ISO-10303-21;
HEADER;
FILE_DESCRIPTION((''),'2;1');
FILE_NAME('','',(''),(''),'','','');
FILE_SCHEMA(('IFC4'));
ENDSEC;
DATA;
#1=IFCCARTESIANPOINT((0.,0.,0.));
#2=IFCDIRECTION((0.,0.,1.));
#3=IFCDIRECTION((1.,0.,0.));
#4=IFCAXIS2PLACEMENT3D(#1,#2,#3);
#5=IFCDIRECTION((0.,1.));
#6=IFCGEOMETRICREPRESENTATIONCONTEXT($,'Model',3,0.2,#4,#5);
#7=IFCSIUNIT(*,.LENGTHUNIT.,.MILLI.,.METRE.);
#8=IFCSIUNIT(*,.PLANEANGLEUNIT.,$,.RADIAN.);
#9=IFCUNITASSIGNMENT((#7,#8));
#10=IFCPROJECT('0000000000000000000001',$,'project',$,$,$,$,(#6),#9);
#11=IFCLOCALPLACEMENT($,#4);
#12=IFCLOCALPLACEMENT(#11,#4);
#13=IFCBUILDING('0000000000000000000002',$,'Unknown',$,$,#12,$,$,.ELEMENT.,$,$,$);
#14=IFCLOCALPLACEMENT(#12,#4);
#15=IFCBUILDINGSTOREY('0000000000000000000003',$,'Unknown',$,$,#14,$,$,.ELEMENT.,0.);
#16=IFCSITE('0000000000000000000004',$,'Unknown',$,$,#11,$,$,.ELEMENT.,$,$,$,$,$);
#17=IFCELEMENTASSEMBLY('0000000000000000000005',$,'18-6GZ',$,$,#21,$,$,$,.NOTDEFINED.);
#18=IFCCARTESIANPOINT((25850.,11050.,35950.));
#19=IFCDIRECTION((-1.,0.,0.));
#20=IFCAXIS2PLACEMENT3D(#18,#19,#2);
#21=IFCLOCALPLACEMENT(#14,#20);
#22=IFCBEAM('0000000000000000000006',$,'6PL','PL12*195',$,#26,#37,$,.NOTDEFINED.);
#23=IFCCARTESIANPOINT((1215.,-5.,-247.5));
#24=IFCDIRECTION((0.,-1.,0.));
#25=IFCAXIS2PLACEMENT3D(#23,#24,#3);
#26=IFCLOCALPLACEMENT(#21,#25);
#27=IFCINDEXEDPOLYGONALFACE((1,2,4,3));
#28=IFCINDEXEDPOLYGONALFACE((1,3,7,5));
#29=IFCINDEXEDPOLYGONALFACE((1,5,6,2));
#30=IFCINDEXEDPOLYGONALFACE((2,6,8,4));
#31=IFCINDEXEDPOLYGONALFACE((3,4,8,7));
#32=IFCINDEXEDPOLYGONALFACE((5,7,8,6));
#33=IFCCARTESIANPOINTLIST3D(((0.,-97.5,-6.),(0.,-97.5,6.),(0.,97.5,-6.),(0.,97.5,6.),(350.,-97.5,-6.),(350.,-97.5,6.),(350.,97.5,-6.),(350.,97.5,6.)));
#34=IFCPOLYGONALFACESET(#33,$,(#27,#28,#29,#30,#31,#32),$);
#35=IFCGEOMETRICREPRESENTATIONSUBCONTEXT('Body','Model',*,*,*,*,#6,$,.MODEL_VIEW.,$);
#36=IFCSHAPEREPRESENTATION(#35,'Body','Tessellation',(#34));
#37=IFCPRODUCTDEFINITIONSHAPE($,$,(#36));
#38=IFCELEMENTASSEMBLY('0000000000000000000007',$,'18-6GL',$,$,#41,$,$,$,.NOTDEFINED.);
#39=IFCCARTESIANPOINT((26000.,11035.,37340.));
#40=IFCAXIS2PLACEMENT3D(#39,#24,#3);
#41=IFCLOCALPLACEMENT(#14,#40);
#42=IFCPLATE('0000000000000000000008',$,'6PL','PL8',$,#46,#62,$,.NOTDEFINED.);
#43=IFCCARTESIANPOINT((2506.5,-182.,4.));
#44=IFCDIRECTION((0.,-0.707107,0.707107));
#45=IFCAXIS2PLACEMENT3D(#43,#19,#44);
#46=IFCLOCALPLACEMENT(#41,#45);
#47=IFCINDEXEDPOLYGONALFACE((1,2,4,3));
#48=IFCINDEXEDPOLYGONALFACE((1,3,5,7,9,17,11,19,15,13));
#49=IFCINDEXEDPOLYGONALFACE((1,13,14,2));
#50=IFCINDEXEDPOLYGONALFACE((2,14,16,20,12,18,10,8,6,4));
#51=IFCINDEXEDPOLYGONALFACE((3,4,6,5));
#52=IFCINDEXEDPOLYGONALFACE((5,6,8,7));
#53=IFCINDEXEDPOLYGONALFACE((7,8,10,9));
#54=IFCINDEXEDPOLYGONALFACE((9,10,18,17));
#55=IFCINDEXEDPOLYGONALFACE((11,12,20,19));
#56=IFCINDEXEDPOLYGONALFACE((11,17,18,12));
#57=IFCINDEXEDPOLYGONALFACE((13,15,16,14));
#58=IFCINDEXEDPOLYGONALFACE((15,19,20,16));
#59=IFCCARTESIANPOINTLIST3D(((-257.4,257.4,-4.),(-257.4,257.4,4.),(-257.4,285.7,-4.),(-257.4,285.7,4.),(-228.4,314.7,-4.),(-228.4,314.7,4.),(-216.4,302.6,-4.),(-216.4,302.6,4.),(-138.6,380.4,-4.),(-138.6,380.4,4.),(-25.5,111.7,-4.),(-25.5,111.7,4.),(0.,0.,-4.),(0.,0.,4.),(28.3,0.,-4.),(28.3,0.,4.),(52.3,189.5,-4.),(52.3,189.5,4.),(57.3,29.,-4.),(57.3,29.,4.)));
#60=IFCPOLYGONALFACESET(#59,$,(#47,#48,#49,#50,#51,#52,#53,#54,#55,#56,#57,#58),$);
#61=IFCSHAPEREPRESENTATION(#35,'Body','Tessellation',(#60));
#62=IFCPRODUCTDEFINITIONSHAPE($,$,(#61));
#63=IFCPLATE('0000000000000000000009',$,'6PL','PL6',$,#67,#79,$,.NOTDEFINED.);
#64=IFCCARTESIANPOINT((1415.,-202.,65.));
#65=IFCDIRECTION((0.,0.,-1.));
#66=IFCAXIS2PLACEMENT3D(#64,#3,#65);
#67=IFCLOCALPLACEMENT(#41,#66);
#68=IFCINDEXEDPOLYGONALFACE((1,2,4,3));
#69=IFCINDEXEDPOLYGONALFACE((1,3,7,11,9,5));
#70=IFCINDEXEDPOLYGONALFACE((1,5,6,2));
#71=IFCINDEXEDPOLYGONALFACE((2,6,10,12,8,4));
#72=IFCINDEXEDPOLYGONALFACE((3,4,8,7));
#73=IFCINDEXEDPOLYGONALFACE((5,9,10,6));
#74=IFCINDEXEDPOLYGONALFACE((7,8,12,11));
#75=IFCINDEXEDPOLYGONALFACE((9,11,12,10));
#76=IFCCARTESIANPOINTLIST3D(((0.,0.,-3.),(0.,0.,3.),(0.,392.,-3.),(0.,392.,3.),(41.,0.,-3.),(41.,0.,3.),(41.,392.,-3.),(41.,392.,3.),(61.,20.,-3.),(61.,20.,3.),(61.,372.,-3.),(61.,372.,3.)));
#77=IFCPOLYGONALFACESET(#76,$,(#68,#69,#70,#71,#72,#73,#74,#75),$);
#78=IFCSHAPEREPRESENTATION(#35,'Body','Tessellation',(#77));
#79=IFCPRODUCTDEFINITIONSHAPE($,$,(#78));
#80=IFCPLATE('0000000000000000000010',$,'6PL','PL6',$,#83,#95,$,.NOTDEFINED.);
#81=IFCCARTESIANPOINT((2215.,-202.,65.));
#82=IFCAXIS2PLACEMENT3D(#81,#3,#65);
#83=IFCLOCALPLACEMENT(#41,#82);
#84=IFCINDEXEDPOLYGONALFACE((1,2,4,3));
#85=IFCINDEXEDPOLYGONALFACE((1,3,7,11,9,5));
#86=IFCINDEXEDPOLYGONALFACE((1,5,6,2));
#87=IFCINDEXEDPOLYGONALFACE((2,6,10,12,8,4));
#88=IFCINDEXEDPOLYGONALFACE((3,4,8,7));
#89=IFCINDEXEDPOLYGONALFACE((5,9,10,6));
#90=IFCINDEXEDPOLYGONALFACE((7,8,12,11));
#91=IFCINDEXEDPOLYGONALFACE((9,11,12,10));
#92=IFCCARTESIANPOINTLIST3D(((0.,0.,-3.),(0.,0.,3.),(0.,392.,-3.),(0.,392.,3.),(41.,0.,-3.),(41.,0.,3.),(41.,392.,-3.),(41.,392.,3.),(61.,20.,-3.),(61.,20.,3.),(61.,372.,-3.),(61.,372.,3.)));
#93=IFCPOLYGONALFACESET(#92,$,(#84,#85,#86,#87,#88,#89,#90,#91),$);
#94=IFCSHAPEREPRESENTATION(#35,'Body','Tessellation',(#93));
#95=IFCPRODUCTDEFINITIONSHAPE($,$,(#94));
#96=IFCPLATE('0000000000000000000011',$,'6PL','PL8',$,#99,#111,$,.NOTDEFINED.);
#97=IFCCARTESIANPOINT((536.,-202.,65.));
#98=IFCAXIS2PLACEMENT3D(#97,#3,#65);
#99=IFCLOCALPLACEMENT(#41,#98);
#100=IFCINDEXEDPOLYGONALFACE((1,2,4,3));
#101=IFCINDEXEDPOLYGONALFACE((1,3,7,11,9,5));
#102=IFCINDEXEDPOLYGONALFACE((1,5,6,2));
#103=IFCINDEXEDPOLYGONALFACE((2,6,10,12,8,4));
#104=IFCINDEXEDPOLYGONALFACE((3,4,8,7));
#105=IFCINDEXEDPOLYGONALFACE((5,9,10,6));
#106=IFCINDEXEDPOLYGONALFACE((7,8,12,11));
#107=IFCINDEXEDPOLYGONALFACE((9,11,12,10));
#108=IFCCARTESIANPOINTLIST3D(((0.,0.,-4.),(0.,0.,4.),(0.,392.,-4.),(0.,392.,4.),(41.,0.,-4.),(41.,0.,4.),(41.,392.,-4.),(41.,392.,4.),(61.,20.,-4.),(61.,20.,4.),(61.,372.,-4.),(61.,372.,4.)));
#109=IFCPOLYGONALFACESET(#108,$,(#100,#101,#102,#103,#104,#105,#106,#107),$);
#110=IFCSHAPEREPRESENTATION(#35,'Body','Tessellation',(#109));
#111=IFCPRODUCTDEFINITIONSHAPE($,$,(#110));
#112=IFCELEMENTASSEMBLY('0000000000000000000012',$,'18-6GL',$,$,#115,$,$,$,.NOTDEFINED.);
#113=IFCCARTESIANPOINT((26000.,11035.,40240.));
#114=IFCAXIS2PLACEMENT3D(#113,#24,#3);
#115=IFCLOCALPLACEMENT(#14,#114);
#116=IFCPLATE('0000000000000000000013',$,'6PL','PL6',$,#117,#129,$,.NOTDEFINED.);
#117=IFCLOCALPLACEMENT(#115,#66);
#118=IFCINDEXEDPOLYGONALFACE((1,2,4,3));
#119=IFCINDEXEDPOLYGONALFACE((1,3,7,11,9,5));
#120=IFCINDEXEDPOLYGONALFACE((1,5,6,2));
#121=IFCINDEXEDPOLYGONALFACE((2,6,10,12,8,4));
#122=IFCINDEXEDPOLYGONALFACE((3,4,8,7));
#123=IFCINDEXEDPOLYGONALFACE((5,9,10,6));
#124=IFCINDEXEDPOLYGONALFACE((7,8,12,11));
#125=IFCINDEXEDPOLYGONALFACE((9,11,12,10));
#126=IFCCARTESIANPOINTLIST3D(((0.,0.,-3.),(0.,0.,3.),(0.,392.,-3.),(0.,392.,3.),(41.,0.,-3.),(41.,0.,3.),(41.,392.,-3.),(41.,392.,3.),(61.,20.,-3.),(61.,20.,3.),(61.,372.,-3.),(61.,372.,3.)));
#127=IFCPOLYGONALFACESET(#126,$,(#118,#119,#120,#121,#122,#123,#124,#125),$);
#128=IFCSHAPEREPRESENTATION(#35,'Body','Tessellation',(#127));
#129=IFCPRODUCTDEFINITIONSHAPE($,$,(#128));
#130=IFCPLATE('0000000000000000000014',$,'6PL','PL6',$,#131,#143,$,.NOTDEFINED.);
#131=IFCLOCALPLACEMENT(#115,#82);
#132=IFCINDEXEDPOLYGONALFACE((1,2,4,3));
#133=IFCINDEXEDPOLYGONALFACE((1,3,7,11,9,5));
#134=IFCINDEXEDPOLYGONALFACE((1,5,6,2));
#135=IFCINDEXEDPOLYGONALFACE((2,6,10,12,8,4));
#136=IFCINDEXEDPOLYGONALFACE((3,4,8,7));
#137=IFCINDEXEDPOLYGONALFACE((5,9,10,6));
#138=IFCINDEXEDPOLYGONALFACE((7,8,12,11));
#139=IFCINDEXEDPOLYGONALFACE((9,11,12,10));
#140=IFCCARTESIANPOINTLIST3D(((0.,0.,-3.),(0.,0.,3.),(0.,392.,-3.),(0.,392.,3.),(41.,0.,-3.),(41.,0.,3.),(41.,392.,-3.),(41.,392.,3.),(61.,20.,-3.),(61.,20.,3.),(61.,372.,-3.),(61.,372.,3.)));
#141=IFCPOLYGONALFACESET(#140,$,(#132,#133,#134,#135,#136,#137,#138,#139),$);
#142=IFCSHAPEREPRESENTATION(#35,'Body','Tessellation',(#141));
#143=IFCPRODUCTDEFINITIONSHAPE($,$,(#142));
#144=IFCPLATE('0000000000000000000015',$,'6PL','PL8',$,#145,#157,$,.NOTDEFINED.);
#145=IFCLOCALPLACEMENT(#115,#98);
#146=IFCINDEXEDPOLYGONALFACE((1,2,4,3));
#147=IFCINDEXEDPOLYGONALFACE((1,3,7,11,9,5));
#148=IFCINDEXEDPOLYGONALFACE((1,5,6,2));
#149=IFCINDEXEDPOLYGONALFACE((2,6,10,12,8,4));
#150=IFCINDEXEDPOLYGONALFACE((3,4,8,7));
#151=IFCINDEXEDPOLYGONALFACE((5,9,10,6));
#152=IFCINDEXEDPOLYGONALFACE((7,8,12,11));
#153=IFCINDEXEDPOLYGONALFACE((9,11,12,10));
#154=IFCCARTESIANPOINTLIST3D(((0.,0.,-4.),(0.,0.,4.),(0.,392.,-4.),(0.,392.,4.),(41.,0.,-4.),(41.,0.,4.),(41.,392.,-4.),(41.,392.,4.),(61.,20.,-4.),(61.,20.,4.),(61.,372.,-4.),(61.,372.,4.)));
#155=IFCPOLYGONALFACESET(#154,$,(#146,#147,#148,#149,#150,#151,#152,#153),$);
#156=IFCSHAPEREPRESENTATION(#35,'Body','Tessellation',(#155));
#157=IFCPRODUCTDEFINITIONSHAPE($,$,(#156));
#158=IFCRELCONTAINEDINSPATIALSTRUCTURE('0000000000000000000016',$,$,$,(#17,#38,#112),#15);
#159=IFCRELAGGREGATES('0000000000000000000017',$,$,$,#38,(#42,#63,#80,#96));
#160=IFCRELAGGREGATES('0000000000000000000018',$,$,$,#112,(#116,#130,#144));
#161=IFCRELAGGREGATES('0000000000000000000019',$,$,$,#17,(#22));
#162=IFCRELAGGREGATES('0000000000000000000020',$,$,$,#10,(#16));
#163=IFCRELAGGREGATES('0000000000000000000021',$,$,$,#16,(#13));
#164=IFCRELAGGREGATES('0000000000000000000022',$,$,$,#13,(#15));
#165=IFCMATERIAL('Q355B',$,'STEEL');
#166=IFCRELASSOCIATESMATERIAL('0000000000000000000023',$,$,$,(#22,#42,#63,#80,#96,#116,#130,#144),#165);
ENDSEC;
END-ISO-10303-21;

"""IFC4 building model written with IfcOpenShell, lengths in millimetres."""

from ifc_helpers import new_model, si_unit, direction, frame, origin_with_axes, place, context, subcontext, project, spatial, line, indexed_curve, outline, extrude, material, element, aggregate, save


model = new_model("IFC4")

# Units and contexts
model_context = context("Model", 3, precision=0.2, world=origin_with_axes(), true_north=direction((0.0, 1.0)))
body_context = subcontext(model_context, "Body", "Model", "MODEL_VIEW")
ifc_project = project(units=[si_unit("LENGTHUNIT", "METRE", prefix="MILLI"), si_unit("PLANEANGLEUNIT", "RADIAN")], contexts=[model_context])

# Site, building, storey
site_placement = place(None, origin_with_axes())
site = spatial("IfcSite", under=ifc_project, at=site_placement, Name="Unknown", CompositionType="ELEMENT")
building_placement = place(site_placement, origin_with_axes())
building = spatial("IfcBuilding", under=site, at=building_placement, Name="Unknown", CompositionType="ELEMENT")
storey_placement = place(building_placement, origin_with_axes())
storey = spatial("IfcBuildingStorey", under=building, at=storey_placement, Name="Unknown", CompositionType="ELEMENT", Elevation=0.0)

# Element assembly, beam
ifc_material_1 = material(Name="Q355B", Category="STEEL")
assembly_1_placement = place(storey_placement, frame((25850.0, 11050.0, 35950.0), z_axis=(-1.0, 0.0, 0.0), x_axis=(0.0, 0.0, 1.0)))
assembly_1 = element("IfcElementAssembly", 1, at=assembly_1_placement, inside=storey, Name="18-6GZ", PredefinedType="NOTDEFINED")
beam_1_placement = place(assembly_1_placement, frame((1215.0, -5.0, -247.5), z_axis=(0.0, -1.0, 0.0), x_axis=(1.0, 0.0, 0.0)))
beam_1 = element("IfcBeam", 2, at=beam_1_placement, material=ifc_material_1, Name="6PL", Description="PL12*195", PredefinedType="NOTDEFINED", context=body_context, shape_type="SolidModel", body=[
    extrude(outline(indexed_curve([(-6.0, -97.5), (6.0, -97.5), (6.0, 97.5), (-6.0, 97.5)], segments=[line(1, 2, 3, 4, 1)])), frame((0.0, 0.0, 0.0), z_axis=(-1.0, 0.0, 0.0), x_axis=(0.0, 0.0, 1.0)), (0.0, 0.0, -1.0), 350.0),
])

# Element assemblies, plates
assembly_2_placement = place(storey_placement, frame((26000.0, 11035.0, 37340.0), z_axis=(0.0, -1.0, 0.0), x_axis=(1.0, 0.0, 0.0)))
assembly_2 = element("IfcElementAssembly", 3, at=assembly_2_placement, inside=storey, Name="18-6GL", PredefinedType="NOTDEFINED")
plate_1_placement = place(assembly_2_placement, frame((2506.5, -182.0, 4.0), z_axis=(-1.0, 0.0, 0.0), x_axis=(0.0, -0.707107, 0.707107)))
plate_1 = element("IfcPlate", 4, at=plate_1_placement, material=ifc_material_1, Name="6PL", Description="PL8", PredefinedType="NOTDEFINED", context=body_context, shape_type="SolidModel", body=[
    extrude(outline(indexed_curve([(0.0, 0.0), (28.3, 0.0), (57.3, 29.0), (-25.5, 111.7), (52.3, 189.5), (-138.6, 380.4), (-216.4, 302.6), (-228.4, 314.7), (-257.4, 285.7), (-257.4, 257.4)], segments=[line(1, 2, 3, 4, 5, 6, 7, 8, 9, 10, 1)])), frame((0.0, 0.0, 4.0), z_axis=(0.0, 0.0, 1.0), x_axis=(1.0, 0.0, 0.0)), (0.0, 0.0, -1.0), 8.0),
])
plate_2_placement = place(assembly_2_placement, frame((1415.0, -202.0, 65.0), z_axis=(1.0, 0.0, 0.0), x_axis=(0.0, 0.0, -1.0)))
plate_2 = element("IfcPlate", 5, at=plate_2_placement, material=ifc_material_1, Name="6PL", Description="PL6", PredefinedType="NOTDEFINED", context=body_context, shape_type="SolidModel", body=[
    extrude(outline(indexed_curve([(0.0, 0.0), (41.0, 0.0), (61.0, 20.0), (61.0, 372.0), (41.0, 392.0), (0.0, 392.0)], segments=[line(1, 2, 3, 4, 5, 6, 1)])), frame((0.0, 0.0, 3.0), z_axis=(0.0, 0.0, 1.0), x_axis=(1.0, 0.0, 0.0)), (0.0, 0.0, -1.0), 6.0),
])
plate_3_placement = place(assembly_2_placement, frame((2215.0, -202.0, 65.0), z_axis=(1.0, 0.0, 0.0), x_axis=(0.0, 0.0, -1.0)))
plate_3 = element("IfcPlate", 6, at=plate_3_placement, material=ifc_material_1, Name="6PL", Description="PL6", PredefinedType="NOTDEFINED", context=body_context, shape_type="SolidModel", body=[
    extrude(outline(indexed_curve([(0.0, 0.0), (41.0, 0.0), (61.0, 20.0), (61.0, 372.0), (41.0, 392.0), (0.0, 392.0)], segments=[line(1, 2, 3, 4, 5, 6, 1)])), frame((0.0, 0.0, 3.0), z_axis=(0.0, 0.0, 1.0), x_axis=(1.0, 0.0, 0.0)), (0.0, 0.0, -1.0), 6.0),
])
plate_4_placement = place(assembly_2_placement, frame((536.0, -202.0, 65.0), z_axis=(1.0, 0.0, 0.0), x_axis=(0.0, 0.0, -1.0)))
plate_4 = element("IfcPlate", 7, at=plate_4_placement, material=ifc_material_1, Name="6PL", Description="PL8", PredefinedType="NOTDEFINED", context=body_context, shape_type="SolidModel", body=[
    extrude(outline(indexed_curve([(0.0, 0.0), (41.0, 0.0), (61.0, 20.0), (61.0, 372.0), (41.0, 392.0), (0.0, 392.0)], segments=[line(1, 2, 3, 4, 5, 6, 1)])), frame((0.0, 0.0, 4.0), z_axis=(0.0, 0.0, 1.0), x_axis=(1.0, 0.0, 0.0)), (0.0, 0.0, -1.0), 8.0),
])
aggregate(assembly_2, [plate_1, plate_2, plate_3, plate_4])
assembly_3_placement = place(storey_placement, frame((26000.0, 11035.0, 40240.0), z_axis=(0.0, -1.0, 0.0), x_axis=(1.0, 0.0, 0.0)))
assembly_3 = element("IfcElementAssembly", 8, at=assembly_3_placement, inside=storey, Name="18-6GL", PredefinedType="NOTDEFINED")
plate_5_placement = place(assembly_3_placement, frame((1415.0, -202.0, 65.0), z_axis=(1.0, 0.0, 0.0), x_axis=(0.0, 0.0, -1.0)))
plate_5 = element("IfcPlate", 9, at=plate_5_placement, material=ifc_material_1, Name="6PL", Description="PL6", PredefinedType="NOTDEFINED", context=body_context, shape_type="SolidModel", body=[
    extrude(outline(indexed_curve([(0.0, 0.0), (41.0, 0.0), (61.0, 20.0), (61.0, 372.0), (41.0, 392.0), (0.0, 392.0)], segments=[line(1, 2, 3, 4, 5, 6, 1)])), frame((0.0, 0.0, 3.0), z_axis=(0.0, 0.0, 1.0), x_axis=(1.0, 0.0, 0.0)), (0.0, 0.0, -1.0), 6.0),
])
plate_6_placement = place(assembly_3_placement, frame((2215.0, -202.0, 65.0), z_axis=(1.0, 0.0, 0.0), x_axis=(0.0, 0.0, -1.0)))
plate_6 = element("IfcPlate", 10, at=plate_6_placement, material=ifc_material_1, Name="6PL", Description="PL6", PredefinedType="NOTDEFINED", context=body_context, shape_type="SolidModel", body=[
    extrude(outline(indexed_curve([(0.0, 0.0), (41.0, 0.0), (61.0, 20.0), (61.0, 372.0), (41.0, 392.0), (0.0, 392.0)], segments=[line(1, 2, 3, 4, 5, 6, 1)])), frame((0.0, 0.0, 3.0), z_axis=(0.0, 0.0, 1.0), x_axis=(1.0, 0.0, 0.0)), (0.0, 0.0, -1.0), 6.0),
])
plate_7_placement = place(assembly_3_placement, frame((536.0, -202.0, 65.0), z_axis=(1.0, 0.0, 0.0), x_axis=(0.0, 0.0, -1.0)))
plate_7 = element("IfcPlate", 11, at=plate_7_placement, material=ifc_material_1, Name="6PL", Description="PL8", PredefinedType="NOTDEFINED", context=body_context, shape_type="SolidModel", body=[
    extrude(outline(indexed_curve([(0.0, 0.0), (41.0, 0.0), (61.0, 20.0), (61.0, 372.0), (41.0, 392.0), (0.0, 392.0)], segments=[line(1, 2, 3, 4, 5, 6, 1)])), frame((0.0, 0.0, 4.0), z_axis=(0.0, 0.0, 1.0), x_axis=(1.0, 0.0, 0.0)), (0.0, 0.0, -1.0), 8.0),
])
aggregate(assembly_3, [plate_5, plate_6, plate_7])

aggregate(assembly_1, [beam_1])

save(model, "model.ifc")
